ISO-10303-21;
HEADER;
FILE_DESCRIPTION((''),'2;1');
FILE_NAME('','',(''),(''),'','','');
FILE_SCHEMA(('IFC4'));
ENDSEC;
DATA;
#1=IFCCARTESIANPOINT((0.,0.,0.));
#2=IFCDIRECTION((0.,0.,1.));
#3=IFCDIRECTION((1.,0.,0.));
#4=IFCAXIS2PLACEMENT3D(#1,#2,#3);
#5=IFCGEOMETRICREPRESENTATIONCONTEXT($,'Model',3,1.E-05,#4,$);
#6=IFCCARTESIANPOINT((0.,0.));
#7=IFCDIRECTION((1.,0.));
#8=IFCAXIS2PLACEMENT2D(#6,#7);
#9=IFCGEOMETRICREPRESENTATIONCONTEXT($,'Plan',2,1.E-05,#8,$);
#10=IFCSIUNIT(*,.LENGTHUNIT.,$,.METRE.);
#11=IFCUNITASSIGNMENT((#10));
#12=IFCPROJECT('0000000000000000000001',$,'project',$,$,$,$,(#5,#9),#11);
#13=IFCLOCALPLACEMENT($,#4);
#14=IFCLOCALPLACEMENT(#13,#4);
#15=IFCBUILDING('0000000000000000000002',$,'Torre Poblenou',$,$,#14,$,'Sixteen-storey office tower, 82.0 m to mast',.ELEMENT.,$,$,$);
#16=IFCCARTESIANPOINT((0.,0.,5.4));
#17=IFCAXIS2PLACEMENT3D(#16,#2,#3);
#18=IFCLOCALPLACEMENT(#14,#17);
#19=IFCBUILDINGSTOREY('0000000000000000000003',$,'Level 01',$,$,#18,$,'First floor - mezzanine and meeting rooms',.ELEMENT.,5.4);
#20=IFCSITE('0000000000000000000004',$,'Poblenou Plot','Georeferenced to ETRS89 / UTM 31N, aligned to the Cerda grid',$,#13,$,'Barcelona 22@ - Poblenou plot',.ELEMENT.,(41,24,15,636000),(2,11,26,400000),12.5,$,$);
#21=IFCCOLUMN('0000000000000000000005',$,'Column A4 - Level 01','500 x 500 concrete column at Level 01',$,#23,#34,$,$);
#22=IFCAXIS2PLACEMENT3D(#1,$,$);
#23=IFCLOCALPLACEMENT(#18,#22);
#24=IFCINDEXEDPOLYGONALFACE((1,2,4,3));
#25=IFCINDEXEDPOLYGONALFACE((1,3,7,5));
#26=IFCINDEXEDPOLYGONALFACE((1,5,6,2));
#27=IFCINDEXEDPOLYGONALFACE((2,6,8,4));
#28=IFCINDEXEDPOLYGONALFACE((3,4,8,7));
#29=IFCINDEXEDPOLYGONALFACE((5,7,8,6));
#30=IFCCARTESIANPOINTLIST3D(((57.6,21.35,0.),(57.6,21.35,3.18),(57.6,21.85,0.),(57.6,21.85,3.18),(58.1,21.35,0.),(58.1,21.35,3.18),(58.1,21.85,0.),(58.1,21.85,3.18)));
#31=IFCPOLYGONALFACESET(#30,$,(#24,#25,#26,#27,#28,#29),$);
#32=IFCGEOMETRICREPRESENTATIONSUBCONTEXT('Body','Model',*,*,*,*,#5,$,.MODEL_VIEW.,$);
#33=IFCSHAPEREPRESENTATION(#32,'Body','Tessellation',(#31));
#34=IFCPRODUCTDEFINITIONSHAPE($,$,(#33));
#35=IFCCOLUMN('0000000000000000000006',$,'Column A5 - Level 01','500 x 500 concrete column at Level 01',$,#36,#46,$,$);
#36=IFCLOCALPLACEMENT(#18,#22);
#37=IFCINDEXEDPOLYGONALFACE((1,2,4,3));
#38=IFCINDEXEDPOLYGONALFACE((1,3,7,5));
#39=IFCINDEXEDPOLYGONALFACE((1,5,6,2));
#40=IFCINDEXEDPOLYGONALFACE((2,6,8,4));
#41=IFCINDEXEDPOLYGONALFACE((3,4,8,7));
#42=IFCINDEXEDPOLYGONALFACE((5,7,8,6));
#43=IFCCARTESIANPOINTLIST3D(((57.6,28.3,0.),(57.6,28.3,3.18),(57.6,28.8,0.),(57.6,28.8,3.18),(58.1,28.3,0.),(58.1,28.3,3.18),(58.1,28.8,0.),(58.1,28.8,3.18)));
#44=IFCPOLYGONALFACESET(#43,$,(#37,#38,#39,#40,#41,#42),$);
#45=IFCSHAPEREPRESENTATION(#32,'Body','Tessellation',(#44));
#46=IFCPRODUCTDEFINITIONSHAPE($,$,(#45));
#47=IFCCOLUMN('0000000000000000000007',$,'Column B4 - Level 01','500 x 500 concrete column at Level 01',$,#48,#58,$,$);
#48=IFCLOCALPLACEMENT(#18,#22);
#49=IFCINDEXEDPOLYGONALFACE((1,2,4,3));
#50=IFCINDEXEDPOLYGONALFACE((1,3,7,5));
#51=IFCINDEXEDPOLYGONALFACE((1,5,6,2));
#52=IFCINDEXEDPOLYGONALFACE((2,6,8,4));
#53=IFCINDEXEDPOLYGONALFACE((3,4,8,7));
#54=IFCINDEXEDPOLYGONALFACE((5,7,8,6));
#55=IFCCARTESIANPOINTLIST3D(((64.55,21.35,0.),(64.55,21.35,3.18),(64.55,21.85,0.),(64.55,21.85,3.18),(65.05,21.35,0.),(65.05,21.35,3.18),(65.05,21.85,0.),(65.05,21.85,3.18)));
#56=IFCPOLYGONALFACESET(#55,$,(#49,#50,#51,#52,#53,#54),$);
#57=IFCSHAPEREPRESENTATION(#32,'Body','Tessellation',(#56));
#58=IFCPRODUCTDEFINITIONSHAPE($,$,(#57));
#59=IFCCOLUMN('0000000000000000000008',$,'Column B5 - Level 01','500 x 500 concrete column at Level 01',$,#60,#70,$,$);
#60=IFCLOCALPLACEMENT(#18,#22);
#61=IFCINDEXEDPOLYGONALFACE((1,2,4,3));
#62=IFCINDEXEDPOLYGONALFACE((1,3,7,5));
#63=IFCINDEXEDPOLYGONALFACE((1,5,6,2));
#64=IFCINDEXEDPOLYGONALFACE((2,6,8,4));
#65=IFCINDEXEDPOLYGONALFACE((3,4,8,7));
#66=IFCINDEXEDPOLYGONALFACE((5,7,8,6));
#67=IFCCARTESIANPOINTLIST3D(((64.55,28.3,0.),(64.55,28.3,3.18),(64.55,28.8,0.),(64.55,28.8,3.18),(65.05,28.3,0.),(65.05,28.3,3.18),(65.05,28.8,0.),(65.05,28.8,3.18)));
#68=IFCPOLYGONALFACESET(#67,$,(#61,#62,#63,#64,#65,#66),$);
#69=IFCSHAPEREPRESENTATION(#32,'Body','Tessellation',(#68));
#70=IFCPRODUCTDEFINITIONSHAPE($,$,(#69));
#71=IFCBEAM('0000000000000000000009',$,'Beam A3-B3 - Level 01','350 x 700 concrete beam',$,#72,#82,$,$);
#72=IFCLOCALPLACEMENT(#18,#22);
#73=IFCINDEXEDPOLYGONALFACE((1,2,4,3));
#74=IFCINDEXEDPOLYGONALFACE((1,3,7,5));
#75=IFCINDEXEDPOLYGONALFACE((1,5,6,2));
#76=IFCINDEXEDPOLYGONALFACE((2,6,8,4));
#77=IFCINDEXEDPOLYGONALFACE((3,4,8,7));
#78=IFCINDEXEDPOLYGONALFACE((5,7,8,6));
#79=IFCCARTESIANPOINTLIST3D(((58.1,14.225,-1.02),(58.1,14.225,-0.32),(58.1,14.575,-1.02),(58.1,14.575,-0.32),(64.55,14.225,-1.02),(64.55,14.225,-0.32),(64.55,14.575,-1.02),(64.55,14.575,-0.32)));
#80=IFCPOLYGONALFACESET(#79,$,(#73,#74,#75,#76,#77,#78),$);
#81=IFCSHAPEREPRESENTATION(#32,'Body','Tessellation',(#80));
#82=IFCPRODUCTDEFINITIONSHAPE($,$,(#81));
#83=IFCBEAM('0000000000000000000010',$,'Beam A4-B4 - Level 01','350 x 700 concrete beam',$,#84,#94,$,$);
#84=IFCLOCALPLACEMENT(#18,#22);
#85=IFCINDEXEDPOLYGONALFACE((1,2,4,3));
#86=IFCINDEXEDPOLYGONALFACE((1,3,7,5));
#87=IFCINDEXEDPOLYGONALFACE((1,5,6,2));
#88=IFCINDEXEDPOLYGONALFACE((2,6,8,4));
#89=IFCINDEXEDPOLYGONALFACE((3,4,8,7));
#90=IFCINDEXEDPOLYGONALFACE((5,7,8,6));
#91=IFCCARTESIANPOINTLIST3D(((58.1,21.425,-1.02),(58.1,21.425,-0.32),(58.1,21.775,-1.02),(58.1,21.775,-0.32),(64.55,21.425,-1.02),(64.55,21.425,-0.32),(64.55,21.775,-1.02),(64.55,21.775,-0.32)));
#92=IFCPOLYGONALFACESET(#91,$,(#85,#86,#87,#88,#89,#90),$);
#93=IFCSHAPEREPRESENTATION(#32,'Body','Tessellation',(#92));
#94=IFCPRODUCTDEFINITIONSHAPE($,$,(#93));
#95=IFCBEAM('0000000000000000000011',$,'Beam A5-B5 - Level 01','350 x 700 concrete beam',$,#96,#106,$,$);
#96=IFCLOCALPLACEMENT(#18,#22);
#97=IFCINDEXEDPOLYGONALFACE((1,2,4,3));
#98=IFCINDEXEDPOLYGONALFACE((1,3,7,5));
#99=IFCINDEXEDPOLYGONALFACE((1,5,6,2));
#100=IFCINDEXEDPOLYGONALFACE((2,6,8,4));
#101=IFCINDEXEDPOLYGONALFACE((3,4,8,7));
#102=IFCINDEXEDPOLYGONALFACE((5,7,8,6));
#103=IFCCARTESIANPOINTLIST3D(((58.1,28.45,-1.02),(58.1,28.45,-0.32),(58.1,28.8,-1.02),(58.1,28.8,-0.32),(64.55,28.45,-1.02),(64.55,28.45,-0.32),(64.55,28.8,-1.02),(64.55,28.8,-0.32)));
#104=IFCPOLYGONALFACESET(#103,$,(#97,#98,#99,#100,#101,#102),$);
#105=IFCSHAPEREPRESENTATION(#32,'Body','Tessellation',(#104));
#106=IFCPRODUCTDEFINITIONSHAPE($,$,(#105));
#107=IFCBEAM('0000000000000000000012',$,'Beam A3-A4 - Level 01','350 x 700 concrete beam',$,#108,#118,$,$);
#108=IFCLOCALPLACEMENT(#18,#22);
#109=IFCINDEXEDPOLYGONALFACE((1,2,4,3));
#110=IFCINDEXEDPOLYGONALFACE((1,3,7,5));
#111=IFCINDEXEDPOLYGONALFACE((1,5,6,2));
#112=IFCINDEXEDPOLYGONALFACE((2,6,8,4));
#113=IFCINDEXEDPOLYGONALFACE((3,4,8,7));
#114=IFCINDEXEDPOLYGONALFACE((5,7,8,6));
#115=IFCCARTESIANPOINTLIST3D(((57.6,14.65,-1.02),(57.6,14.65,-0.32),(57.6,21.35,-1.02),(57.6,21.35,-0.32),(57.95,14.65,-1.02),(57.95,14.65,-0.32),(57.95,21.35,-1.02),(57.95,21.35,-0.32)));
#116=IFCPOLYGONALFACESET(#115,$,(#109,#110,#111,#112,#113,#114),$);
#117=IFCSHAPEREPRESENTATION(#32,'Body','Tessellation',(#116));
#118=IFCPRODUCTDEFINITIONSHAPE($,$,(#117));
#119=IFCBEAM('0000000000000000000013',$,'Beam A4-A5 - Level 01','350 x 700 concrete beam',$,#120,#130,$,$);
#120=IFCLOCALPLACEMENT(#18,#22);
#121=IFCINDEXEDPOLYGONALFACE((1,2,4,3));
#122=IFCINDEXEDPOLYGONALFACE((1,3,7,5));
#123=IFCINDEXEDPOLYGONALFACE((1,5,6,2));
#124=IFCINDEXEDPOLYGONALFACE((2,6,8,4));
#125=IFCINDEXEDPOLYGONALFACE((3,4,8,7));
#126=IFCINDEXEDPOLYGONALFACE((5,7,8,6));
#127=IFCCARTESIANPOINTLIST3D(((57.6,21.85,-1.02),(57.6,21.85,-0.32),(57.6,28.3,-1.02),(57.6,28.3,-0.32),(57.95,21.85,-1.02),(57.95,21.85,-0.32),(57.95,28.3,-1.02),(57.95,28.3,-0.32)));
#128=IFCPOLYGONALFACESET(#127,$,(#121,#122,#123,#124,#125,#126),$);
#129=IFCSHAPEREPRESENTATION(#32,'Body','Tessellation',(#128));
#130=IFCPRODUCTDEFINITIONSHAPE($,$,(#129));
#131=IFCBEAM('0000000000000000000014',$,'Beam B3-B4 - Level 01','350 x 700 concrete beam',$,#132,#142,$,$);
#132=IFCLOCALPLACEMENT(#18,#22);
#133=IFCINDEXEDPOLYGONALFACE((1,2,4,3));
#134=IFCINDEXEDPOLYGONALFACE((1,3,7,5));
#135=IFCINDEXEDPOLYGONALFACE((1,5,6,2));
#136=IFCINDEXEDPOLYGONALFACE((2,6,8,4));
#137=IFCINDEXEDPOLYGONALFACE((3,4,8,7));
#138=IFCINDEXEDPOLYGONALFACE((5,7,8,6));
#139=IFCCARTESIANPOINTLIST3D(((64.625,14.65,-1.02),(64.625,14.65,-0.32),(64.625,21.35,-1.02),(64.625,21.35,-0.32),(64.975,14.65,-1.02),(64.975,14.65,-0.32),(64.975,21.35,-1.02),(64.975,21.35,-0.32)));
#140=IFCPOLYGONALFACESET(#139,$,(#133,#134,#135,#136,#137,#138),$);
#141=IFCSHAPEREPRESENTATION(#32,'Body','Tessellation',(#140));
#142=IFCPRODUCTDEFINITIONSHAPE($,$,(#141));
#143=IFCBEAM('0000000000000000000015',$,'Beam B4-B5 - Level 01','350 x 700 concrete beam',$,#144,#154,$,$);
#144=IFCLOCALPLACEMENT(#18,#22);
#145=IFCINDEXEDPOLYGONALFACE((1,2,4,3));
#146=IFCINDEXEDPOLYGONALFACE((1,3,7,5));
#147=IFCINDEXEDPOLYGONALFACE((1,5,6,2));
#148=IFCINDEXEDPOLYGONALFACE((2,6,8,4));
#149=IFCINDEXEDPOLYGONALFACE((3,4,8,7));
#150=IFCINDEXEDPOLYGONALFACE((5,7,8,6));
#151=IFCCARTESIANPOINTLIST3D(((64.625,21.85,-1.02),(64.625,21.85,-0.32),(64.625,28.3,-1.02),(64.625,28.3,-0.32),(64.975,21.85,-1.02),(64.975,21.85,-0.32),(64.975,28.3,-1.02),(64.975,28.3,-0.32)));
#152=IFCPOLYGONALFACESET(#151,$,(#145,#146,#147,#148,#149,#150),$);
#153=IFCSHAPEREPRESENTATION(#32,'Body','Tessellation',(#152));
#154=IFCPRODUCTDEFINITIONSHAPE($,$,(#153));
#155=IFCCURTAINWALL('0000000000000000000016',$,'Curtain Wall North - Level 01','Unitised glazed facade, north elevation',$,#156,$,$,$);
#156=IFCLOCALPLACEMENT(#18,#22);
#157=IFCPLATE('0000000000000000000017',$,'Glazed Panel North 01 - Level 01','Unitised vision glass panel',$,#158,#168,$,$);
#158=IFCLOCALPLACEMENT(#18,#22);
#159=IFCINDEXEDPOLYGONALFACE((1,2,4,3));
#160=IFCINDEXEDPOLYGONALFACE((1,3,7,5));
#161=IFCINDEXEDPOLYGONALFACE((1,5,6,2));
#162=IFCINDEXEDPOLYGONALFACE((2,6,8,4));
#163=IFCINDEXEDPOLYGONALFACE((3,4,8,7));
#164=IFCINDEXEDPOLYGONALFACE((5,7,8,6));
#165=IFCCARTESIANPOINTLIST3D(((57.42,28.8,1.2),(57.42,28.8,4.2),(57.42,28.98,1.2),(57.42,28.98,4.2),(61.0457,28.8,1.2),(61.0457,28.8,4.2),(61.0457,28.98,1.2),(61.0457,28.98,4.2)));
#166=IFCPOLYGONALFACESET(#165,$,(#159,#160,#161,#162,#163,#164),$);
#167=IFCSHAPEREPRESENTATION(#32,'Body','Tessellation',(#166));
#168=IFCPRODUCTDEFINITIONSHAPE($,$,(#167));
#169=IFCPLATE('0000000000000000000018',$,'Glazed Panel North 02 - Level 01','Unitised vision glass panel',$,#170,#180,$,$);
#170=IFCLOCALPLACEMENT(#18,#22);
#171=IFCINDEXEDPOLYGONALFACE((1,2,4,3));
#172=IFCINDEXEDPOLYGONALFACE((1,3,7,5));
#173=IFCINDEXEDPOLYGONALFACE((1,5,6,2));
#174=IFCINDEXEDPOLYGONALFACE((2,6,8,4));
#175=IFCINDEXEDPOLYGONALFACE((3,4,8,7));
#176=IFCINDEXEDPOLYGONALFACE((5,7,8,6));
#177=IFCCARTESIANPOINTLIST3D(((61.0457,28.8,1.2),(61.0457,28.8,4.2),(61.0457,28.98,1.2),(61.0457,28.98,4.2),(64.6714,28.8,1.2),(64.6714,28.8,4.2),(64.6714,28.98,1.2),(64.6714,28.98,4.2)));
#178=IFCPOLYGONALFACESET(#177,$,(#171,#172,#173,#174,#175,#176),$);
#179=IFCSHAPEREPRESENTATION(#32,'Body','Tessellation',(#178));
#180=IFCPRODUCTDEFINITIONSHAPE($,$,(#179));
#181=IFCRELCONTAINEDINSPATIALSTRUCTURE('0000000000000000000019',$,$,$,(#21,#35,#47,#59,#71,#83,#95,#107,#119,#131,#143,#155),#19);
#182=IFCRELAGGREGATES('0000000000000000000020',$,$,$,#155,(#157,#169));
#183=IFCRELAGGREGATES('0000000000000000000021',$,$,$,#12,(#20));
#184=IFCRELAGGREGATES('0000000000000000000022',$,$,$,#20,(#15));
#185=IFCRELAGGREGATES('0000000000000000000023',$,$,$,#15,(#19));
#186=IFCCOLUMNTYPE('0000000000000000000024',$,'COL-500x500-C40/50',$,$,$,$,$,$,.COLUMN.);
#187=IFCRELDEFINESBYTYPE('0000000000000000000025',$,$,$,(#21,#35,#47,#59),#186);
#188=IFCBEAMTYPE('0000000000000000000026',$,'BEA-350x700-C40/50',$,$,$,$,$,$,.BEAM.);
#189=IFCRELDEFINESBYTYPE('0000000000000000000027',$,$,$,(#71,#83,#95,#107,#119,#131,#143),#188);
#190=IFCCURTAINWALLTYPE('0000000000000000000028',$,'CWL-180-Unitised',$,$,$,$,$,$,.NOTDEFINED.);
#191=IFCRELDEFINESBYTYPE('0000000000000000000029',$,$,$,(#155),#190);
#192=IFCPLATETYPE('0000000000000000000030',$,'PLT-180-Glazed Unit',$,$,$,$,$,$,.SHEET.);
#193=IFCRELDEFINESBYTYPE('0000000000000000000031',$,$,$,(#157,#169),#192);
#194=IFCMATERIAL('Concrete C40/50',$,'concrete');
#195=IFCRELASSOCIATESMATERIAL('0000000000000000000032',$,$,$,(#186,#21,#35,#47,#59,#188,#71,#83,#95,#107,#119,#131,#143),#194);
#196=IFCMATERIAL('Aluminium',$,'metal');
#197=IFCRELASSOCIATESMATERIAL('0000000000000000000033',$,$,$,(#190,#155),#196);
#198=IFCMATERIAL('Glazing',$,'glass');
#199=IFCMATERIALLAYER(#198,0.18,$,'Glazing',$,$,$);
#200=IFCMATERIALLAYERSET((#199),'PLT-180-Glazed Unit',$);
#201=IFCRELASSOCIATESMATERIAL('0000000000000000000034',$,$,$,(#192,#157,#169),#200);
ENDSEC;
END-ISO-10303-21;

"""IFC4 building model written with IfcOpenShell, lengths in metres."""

from ifc_helpers import new_model, si_unit, frame, origin_with_axes, origin_2d_with_axis, place, context, subcontext, project, spatial, line, indexed_curve, rectangle, outline, extrude, material, layer, layer_set, layer_usage, material_profile, profile_set, profile_usage, type_object, element, aggregate, save


model = new_model("IFC4")

# Units and contexts
model_context = context("Model", 3, precision=1e-05, world=origin_with_axes())
plan_context = context("Plan", 2, precision=1e-05, world=origin_2d_with_axis())
body_context = subcontext(model_context, "Body", "Model", "MODEL_VIEW")
ifc_project = project(units=[si_unit("LENGTHUNIT", "METRE")], contexts=[model_context, plan_context])

# Site, building, storey
site_placement = place(None, origin_with_axes())
site = spatial("IfcSite", under=ifc_project, at=site_placement, Name="Poblenou Plot", Description="Georeferenced to ETRS89 / UTM 31N, aligned to the Cerda grid", LongName="Barcelona 22@ - Poblenou plot", CompositionType="ELEMENT", RefLatitude=(41, 24, 15, 636000), RefLongitude=(2, 11, 26, 400000), RefElevation=12.5)
building_placement = place(site_placement, origin_with_axes())
building = spatial("IfcBuilding", under=site, at=building_placement, Name="Torre Poblenou", LongName="Sixteen-storey office tower, 82.0 m to mast", CompositionType="ELEMENT")
storey_placement = place(building_placement, frame((0.0, 0.0, 5.4), z_axis=(0.0, 0.0, 1.0), x_axis=(1.0, 0.0, 0.0)))
storey = spatial("IfcBuildingStorey", under=building, at=storey_placement, Name="Level 01", LongName="First floor - mezzanine and meeting rooms", CompositionType="ELEMENT", Elevation=5.4)

# Columns
ifc_material_1 = material(Name="Concrete C40/50", Category="concrete")
ifc_material_profile_1 = material_profile(ifc_material_1, rectangle(XDim=0.5, YDim=0.5))
ifc_profile_set_1 = profile_set([ifc_material_profile_1], Name="COL-500x500-C40/50")
ifc_profile_usage_1 = profile_usage(ifc_profile_set_1)
column_type = type_object("IfcColumnType", Name="COL-500x500-C40/50", PredefinedType="COLUMN", material=ifc_profile_set_1)
column_1_placement = place(storey_placement, frame((57.6, 21.35, 0.0), z_axis=(0.0, 0.0, 1.0), x_axis=(1.0, 0.0, 0.0)))
element("IfcColumn", 1, at=column_1_placement, inside=storey, type_object=column_type, material=ifc_profile_usage_1, Name="Column A4 - Level 01", Description="500 x 500 concrete column at Level 01", context=body_context, shape_type="SweptSolid", body=[
    extrude(outline(indexed_curve([(0.0, 0.0), (0.5, 0.0), (0.5, 0.5), (0.0, 0.5)], segments=[line(1, 2, 3, 4, 1)])), origin_with_axes(), (0.0, 0.0, 1.0), 3.18),
])
ifc_profile_usage_2 = profile_usage(ifc_profile_set_1)
column_2_placement = place(storey_placement, frame((57.6, 28.3, 0.0), z_axis=(0.0, 0.0, 1.0), x_axis=(1.0, 0.0, 0.0)))
element("IfcColumn", 2, at=column_2_placement, inside=storey, type_object=column_type, material=ifc_profile_usage_2, Name="Column A5 - Level 01", Description="500 x 500 concrete column at Level 01", context=body_context, shape_type="SweptSolid", body=[
    extrude(outline(indexed_curve([(0.0, 0.0), (0.5, 0.0), (0.5, 0.5), (0.0, 0.5)], segments=[line(1, 2, 3, 4, 1)])), origin_with_axes(), (0.0, 0.0, 1.0), 3.18),
])
ifc_profile_usage_3 = profile_usage(ifc_profile_set_1)
column_3_placement = place(storey_placement, frame((64.55, 21.35, 0.0), z_axis=(0.0, 0.0, 1.0), x_axis=(1.0, 0.0, 0.0)))
element("IfcColumn", 3, at=column_3_placement, inside=storey, type_object=column_type, material=ifc_profile_usage_3, Name="Column B4 - Level 01", Description="500 x 500 concrete column at Level 01", context=body_context, shape_type="SweptSolid", body=[
    extrude(outline(indexed_curve([(0.0, 0.0), (0.5, 0.0), (0.5, 0.5), (0.0, 0.5)], segments=[line(1, 2, 3, 4, 1)])), origin_with_axes(), (0.0, 0.0, 1.0), 3.18),
])
ifc_profile_usage_4 = profile_usage(ifc_profile_set_1)
column_4_placement = place(storey_placement, frame((64.55, 28.3, 0.0), z_axis=(0.0, 0.0, 1.0), x_axis=(1.0, 0.0, 0.0)))
element("IfcColumn", 4, at=column_4_placement, inside=storey, type_object=column_type, material=ifc_profile_usage_4, Name="Column B5 - Level 01", Description="500 x 500 concrete column at Level 01", context=body_context, shape_type="SweptSolid", body=[
    extrude(outline(indexed_curve([(0.0, 0.0), (0.5, 0.0), (0.5, 0.5), (0.0, 0.5)], segments=[line(1, 2, 3, 4, 1)])), origin_with_axes(), (0.0, 0.0, 1.0), 3.18),
])

# Beams
ifc_material_profile_2 = material_profile(ifc_material_1, rectangle(XDim=0.35, YDim=0.7))
ifc_profile_set_2 = profile_set([ifc_material_profile_2], Name="BEA-350x700-C40/50")
ifc_profile_usage_5 = profile_usage(ifc_profile_set_2)
beam_type = type_object("IfcBeamType", Name="BEA-350x700-C40/50", PredefinedType="BEAM", material=ifc_profile_set_2)
beam_1_placement = place(storey_placement, frame((58.1, 14.225, -1.02), z_axis=(0.0, 0.0, 1.0), x_axis=(1.0, 0.0, 0.0)))
element("IfcBeam", 5, at=beam_1_placement, inside=storey, type_object=beam_type, material=ifc_profile_usage_5, Name="Beam A3-B3 - Level 01", Description="350 x 700 concrete beam", context=body_context, shape_type="SweptSolid", body=[
    extrude(outline(indexed_curve([(0.0, 0.0), (6.45, 0.0), (6.45, 0.35), (0.0, 0.35)], segments=[line(1, 2, 3, 4, 1)])), origin_with_axes(), (0.0, 0.0, 1.0), 0.7),
])
ifc_profile_usage_6 = profile_usage(ifc_profile_set_2)
beam_2_placement = place(storey_placement, frame((58.1, 21.425, -1.02), z_axis=(0.0, 0.0, 1.0), x_axis=(1.0, 0.0, 0.0)))
element("IfcBeam", 6, at=beam_2_placement, inside=storey, type_object=beam_type, material=ifc_profile_usage_6, Name="Beam A4-B4 - Level 01", Description="350 x 700 concrete beam", context=body_context, shape_type="SweptSolid", body=[
    extrude(outline(indexed_curve([(0.0, 0.0), (6.45, 0.0), (6.45, 0.35), (0.0, 0.35)], segments=[line(1, 2, 3, 4, 1)])), origin_with_axes(), (0.0, 0.0, 1.0), 0.7),
])
ifc_profile_usage_7 = profile_usage(ifc_profile_set_2)
beam_3_placement = place(storey_placement, frame((58.1, 28.45, -1.02), z_axis=(0.0, 0.0, 1.0), x_axis=(1.0, 0.0, 0.0)))
element("IfcBeam", 7, at=beam_3_placement, inside=storey, type_object=beam_type, material=ifc_profile_usage_7, Name="Beam A5-B5 - Level 01", Description="350 x 700 concrete beam", context=body_context, shape_type="SweptSolid", body=[
    extrude(outline(indexed_curve([(0.0, 0.0), (6.45, 0.0), (6.45, 0.35), (0.0, 0.35)], segments=[line(1, 2, 3, 4, 1)])), origin_with_axes(), (0.0, 0.0, 1.0), 0.7),
])
ifc_profile_usage_8 = profile_usage(ifc_profile_set_2)
beam_4_placement = place(storey_placement, frame((57.95, 14.65, -1.02), z_axis=(0.0, 0.0, 1.0), x_axis=(0.0, 1.0, 0.0)))
element("IfcBeam", 8, at=beam_4_placement, inside=storey, type_object=beam_type, material=ifc_profile_usage_8, Name="Beam A3-A4 - Level 01", Description="350 x 700 concrete beam", context=body_context, shape_type="SweptSolid", body=[
    extrude(outline(indexed_curve([(0.0, 0.0), (6.7, 0.0), (6.7, 0.35), (0.0, 0.35)], segments=[line(1, 2, 3, 4, 1)])), origin_with_axes(), (0.0, 0.0, 1.0), 0.7),
])
ifc_profile_usage_9 = profile_usage(ifc_profile_set_2)
beam_5_placement = place(storey_placement, frame((57.95, 21.85, -1.02), z_axis=(0.0, 0.0, 1.0), x_axis=(0.0, 1.0, 0.0)))
element("IfcBeam", 9, at=beam_5_placement, inside=storey, type_object=beam_type, material=ifc_profile_usage_9, Name="Beam A4-A5 - Level 01", Description="350 x 700 concrete beam", context=body_context, shape_type="SweptSolid", body=[
    extrude(outline(indexed_curve([(0.0, 0.0), (6.45, 0.0), (6.45, 0.35), (0.0, 0.35)], segments=[line(1, 2, 3, 4, 1)])), origin_with_axes(), (0.0, 0.0, 1.0), 0.7),
])
ifc_profile_usage_10 = profile_usage(ifc_profile_set_2)
beam_6_placement = place(storey_placement, frame((64.975, 14.65, -1.02), z_axis=(0.0, 0.0, 1.0), x_axis=(0.0, 1.0, 0.0)))
element("IfcBeam", 10, at=beam_6_placement, inside=storey, type_object=beam_type, material=ifc_profile_usage_10, Name="Beam B3-B4 - Level 01", Description="350 x 700 concrete beam", context=body_context, shape_type="SweptSolid", body=[
    extrude(outline(indexed_curve([(0.0, 0.0), (6.7, 0.0), (6.7, 0.35), (0.0, 0.35)], segments=[line(1, 2, 3, 4, 1)])), origin_with_axes(), (0.0, 0.0, 1.0), 0.7),
])
ifc_profile_usage_11 = profile_usage(ifc_profile_set_2)
beam_7_placement = place(storey_placement, frame((64.975, 21.85, -1.02), z_axis=(0.0, 0.0, 1.0), x_axis=(0.0, 1.0, 0.0)))
element("IfcBeam", 11, at=beam_7_placement, inside=storey, type_object=beam_type, material=ifc_profile_usage_11, Name="Beam B4-B5 - Level 01", Description="350 x 700 concrete beam", context=body_context, shape_type="SweptSolid", body=[
    extrude(outline(indexed_curve([(0.0, 0.0), (6.45, 0.0), (6.45, 0.35), (0.0, 0.35)], segments=[line(1, 2, 3, 4, 1)])), origin_with_axes(), (0.0, 0.0, 1.0), 0.7),
])

# Curtain wall, plates
ifc_material_2 = material(Name="Aluminium", Category="metal")
curtain_wall_type = type_object("IfcCurtainWallType", Name="CWL-180-Unitised", PredefinedType="NOTDEFINED", material=ifc_material_2)
curtain_wall_1_placement = place(storey_placement, frame((57.42, 28.8, 0.0), z_axis=(0.0, 0.0, 1.0), x_axis=(1.0, 0.0, 0.0)))
curtain_wall_1 = element("IfcCurtainWall", 12, at=curtain_wall_1_placement, inside=storey, type_object=curtain_wall_type, material=ifc_material_2, Name="Curtain Wall North - Level 01", Description="Unitised glazed facade, north elevation")
ifc_material_3 = material(Name="Glazing", Category="glass")
ifc_layer_1 = layer(ifc_material_3, 0.18, Name="Glazing")
ifc_layer_set_1 = layer_set([ifc_layer_1], Name="PLT-180-Glazed Unit")
ifc_layer_usage_1 = layer_usage(ifc_layer_set_1, "AXIS2", "POSITIVE", 0.0)
plate_type_1 = type_object("IfcPlateType", Name="PLT-180-Glazed Unit", PredefinedType="SHEET", material=ifc_layer_set_1)
plate_1_placement = place(curtain_wall_1_placement, frame((0.0, 0.0, 1.2), z_axis=(0.0, 0.0, 1.0), x_axis=(1.0, 0.0, 0.0)))
plate_1 = element("IfcPlate", 13, at=plate_1_placement, type_object=plate_type_1, material=ifc_layer_usage_1, Name="Glazed Panel North 01 - Level 01", Description="Unitised vision glass panel", context=body_context, shape_type="SweptSolid", body=[
    extrude(outline(indexed_curve([(0.0, 0.0), (3.6257, 0.0), (3.6257, 0.18), (0.0, 0.18)], segments=[line(1, 2, 3, 4, 1)])), origin_with_axes(), (0.0, 0.0, 1.0), 3.0),
])
ifc_layer_usage_2 = layer_usage(ifc_layer_set_1, "AXIS2", "POSITIVE", 0.0)
plate_2_placement = place(curtain_wall_1_placement, frame((3.6257, 0.0, 1.2), z_axis=(0.0, 0.0, 1.0), x_axis=(1.0, 0.0, 0.0)))
plate_2 = element("IfcPlate", 14, at=plate_2_placement, type_object=plate_type_1, material=ifc_layer_usage_2, Name="Glazed Panel North 02 - Level 01", Description="Unitised vision glass panel", context=body_context, shape_type="SweptSolid", body=[
    extrude(outline(indexed_curve([(0.0, 0.0), (3.6257, 0.0), (3.6257, 0.18), (0.0, 0.18)], segments=[line(1, 2, 3, 4, 1)])), origin_with_axes(), (0.0, 0.0, 1.0), 3.0),
])

aggregate(curtain_wall_1, [plate_1, plate_2])

save(model, "model.ifc")
